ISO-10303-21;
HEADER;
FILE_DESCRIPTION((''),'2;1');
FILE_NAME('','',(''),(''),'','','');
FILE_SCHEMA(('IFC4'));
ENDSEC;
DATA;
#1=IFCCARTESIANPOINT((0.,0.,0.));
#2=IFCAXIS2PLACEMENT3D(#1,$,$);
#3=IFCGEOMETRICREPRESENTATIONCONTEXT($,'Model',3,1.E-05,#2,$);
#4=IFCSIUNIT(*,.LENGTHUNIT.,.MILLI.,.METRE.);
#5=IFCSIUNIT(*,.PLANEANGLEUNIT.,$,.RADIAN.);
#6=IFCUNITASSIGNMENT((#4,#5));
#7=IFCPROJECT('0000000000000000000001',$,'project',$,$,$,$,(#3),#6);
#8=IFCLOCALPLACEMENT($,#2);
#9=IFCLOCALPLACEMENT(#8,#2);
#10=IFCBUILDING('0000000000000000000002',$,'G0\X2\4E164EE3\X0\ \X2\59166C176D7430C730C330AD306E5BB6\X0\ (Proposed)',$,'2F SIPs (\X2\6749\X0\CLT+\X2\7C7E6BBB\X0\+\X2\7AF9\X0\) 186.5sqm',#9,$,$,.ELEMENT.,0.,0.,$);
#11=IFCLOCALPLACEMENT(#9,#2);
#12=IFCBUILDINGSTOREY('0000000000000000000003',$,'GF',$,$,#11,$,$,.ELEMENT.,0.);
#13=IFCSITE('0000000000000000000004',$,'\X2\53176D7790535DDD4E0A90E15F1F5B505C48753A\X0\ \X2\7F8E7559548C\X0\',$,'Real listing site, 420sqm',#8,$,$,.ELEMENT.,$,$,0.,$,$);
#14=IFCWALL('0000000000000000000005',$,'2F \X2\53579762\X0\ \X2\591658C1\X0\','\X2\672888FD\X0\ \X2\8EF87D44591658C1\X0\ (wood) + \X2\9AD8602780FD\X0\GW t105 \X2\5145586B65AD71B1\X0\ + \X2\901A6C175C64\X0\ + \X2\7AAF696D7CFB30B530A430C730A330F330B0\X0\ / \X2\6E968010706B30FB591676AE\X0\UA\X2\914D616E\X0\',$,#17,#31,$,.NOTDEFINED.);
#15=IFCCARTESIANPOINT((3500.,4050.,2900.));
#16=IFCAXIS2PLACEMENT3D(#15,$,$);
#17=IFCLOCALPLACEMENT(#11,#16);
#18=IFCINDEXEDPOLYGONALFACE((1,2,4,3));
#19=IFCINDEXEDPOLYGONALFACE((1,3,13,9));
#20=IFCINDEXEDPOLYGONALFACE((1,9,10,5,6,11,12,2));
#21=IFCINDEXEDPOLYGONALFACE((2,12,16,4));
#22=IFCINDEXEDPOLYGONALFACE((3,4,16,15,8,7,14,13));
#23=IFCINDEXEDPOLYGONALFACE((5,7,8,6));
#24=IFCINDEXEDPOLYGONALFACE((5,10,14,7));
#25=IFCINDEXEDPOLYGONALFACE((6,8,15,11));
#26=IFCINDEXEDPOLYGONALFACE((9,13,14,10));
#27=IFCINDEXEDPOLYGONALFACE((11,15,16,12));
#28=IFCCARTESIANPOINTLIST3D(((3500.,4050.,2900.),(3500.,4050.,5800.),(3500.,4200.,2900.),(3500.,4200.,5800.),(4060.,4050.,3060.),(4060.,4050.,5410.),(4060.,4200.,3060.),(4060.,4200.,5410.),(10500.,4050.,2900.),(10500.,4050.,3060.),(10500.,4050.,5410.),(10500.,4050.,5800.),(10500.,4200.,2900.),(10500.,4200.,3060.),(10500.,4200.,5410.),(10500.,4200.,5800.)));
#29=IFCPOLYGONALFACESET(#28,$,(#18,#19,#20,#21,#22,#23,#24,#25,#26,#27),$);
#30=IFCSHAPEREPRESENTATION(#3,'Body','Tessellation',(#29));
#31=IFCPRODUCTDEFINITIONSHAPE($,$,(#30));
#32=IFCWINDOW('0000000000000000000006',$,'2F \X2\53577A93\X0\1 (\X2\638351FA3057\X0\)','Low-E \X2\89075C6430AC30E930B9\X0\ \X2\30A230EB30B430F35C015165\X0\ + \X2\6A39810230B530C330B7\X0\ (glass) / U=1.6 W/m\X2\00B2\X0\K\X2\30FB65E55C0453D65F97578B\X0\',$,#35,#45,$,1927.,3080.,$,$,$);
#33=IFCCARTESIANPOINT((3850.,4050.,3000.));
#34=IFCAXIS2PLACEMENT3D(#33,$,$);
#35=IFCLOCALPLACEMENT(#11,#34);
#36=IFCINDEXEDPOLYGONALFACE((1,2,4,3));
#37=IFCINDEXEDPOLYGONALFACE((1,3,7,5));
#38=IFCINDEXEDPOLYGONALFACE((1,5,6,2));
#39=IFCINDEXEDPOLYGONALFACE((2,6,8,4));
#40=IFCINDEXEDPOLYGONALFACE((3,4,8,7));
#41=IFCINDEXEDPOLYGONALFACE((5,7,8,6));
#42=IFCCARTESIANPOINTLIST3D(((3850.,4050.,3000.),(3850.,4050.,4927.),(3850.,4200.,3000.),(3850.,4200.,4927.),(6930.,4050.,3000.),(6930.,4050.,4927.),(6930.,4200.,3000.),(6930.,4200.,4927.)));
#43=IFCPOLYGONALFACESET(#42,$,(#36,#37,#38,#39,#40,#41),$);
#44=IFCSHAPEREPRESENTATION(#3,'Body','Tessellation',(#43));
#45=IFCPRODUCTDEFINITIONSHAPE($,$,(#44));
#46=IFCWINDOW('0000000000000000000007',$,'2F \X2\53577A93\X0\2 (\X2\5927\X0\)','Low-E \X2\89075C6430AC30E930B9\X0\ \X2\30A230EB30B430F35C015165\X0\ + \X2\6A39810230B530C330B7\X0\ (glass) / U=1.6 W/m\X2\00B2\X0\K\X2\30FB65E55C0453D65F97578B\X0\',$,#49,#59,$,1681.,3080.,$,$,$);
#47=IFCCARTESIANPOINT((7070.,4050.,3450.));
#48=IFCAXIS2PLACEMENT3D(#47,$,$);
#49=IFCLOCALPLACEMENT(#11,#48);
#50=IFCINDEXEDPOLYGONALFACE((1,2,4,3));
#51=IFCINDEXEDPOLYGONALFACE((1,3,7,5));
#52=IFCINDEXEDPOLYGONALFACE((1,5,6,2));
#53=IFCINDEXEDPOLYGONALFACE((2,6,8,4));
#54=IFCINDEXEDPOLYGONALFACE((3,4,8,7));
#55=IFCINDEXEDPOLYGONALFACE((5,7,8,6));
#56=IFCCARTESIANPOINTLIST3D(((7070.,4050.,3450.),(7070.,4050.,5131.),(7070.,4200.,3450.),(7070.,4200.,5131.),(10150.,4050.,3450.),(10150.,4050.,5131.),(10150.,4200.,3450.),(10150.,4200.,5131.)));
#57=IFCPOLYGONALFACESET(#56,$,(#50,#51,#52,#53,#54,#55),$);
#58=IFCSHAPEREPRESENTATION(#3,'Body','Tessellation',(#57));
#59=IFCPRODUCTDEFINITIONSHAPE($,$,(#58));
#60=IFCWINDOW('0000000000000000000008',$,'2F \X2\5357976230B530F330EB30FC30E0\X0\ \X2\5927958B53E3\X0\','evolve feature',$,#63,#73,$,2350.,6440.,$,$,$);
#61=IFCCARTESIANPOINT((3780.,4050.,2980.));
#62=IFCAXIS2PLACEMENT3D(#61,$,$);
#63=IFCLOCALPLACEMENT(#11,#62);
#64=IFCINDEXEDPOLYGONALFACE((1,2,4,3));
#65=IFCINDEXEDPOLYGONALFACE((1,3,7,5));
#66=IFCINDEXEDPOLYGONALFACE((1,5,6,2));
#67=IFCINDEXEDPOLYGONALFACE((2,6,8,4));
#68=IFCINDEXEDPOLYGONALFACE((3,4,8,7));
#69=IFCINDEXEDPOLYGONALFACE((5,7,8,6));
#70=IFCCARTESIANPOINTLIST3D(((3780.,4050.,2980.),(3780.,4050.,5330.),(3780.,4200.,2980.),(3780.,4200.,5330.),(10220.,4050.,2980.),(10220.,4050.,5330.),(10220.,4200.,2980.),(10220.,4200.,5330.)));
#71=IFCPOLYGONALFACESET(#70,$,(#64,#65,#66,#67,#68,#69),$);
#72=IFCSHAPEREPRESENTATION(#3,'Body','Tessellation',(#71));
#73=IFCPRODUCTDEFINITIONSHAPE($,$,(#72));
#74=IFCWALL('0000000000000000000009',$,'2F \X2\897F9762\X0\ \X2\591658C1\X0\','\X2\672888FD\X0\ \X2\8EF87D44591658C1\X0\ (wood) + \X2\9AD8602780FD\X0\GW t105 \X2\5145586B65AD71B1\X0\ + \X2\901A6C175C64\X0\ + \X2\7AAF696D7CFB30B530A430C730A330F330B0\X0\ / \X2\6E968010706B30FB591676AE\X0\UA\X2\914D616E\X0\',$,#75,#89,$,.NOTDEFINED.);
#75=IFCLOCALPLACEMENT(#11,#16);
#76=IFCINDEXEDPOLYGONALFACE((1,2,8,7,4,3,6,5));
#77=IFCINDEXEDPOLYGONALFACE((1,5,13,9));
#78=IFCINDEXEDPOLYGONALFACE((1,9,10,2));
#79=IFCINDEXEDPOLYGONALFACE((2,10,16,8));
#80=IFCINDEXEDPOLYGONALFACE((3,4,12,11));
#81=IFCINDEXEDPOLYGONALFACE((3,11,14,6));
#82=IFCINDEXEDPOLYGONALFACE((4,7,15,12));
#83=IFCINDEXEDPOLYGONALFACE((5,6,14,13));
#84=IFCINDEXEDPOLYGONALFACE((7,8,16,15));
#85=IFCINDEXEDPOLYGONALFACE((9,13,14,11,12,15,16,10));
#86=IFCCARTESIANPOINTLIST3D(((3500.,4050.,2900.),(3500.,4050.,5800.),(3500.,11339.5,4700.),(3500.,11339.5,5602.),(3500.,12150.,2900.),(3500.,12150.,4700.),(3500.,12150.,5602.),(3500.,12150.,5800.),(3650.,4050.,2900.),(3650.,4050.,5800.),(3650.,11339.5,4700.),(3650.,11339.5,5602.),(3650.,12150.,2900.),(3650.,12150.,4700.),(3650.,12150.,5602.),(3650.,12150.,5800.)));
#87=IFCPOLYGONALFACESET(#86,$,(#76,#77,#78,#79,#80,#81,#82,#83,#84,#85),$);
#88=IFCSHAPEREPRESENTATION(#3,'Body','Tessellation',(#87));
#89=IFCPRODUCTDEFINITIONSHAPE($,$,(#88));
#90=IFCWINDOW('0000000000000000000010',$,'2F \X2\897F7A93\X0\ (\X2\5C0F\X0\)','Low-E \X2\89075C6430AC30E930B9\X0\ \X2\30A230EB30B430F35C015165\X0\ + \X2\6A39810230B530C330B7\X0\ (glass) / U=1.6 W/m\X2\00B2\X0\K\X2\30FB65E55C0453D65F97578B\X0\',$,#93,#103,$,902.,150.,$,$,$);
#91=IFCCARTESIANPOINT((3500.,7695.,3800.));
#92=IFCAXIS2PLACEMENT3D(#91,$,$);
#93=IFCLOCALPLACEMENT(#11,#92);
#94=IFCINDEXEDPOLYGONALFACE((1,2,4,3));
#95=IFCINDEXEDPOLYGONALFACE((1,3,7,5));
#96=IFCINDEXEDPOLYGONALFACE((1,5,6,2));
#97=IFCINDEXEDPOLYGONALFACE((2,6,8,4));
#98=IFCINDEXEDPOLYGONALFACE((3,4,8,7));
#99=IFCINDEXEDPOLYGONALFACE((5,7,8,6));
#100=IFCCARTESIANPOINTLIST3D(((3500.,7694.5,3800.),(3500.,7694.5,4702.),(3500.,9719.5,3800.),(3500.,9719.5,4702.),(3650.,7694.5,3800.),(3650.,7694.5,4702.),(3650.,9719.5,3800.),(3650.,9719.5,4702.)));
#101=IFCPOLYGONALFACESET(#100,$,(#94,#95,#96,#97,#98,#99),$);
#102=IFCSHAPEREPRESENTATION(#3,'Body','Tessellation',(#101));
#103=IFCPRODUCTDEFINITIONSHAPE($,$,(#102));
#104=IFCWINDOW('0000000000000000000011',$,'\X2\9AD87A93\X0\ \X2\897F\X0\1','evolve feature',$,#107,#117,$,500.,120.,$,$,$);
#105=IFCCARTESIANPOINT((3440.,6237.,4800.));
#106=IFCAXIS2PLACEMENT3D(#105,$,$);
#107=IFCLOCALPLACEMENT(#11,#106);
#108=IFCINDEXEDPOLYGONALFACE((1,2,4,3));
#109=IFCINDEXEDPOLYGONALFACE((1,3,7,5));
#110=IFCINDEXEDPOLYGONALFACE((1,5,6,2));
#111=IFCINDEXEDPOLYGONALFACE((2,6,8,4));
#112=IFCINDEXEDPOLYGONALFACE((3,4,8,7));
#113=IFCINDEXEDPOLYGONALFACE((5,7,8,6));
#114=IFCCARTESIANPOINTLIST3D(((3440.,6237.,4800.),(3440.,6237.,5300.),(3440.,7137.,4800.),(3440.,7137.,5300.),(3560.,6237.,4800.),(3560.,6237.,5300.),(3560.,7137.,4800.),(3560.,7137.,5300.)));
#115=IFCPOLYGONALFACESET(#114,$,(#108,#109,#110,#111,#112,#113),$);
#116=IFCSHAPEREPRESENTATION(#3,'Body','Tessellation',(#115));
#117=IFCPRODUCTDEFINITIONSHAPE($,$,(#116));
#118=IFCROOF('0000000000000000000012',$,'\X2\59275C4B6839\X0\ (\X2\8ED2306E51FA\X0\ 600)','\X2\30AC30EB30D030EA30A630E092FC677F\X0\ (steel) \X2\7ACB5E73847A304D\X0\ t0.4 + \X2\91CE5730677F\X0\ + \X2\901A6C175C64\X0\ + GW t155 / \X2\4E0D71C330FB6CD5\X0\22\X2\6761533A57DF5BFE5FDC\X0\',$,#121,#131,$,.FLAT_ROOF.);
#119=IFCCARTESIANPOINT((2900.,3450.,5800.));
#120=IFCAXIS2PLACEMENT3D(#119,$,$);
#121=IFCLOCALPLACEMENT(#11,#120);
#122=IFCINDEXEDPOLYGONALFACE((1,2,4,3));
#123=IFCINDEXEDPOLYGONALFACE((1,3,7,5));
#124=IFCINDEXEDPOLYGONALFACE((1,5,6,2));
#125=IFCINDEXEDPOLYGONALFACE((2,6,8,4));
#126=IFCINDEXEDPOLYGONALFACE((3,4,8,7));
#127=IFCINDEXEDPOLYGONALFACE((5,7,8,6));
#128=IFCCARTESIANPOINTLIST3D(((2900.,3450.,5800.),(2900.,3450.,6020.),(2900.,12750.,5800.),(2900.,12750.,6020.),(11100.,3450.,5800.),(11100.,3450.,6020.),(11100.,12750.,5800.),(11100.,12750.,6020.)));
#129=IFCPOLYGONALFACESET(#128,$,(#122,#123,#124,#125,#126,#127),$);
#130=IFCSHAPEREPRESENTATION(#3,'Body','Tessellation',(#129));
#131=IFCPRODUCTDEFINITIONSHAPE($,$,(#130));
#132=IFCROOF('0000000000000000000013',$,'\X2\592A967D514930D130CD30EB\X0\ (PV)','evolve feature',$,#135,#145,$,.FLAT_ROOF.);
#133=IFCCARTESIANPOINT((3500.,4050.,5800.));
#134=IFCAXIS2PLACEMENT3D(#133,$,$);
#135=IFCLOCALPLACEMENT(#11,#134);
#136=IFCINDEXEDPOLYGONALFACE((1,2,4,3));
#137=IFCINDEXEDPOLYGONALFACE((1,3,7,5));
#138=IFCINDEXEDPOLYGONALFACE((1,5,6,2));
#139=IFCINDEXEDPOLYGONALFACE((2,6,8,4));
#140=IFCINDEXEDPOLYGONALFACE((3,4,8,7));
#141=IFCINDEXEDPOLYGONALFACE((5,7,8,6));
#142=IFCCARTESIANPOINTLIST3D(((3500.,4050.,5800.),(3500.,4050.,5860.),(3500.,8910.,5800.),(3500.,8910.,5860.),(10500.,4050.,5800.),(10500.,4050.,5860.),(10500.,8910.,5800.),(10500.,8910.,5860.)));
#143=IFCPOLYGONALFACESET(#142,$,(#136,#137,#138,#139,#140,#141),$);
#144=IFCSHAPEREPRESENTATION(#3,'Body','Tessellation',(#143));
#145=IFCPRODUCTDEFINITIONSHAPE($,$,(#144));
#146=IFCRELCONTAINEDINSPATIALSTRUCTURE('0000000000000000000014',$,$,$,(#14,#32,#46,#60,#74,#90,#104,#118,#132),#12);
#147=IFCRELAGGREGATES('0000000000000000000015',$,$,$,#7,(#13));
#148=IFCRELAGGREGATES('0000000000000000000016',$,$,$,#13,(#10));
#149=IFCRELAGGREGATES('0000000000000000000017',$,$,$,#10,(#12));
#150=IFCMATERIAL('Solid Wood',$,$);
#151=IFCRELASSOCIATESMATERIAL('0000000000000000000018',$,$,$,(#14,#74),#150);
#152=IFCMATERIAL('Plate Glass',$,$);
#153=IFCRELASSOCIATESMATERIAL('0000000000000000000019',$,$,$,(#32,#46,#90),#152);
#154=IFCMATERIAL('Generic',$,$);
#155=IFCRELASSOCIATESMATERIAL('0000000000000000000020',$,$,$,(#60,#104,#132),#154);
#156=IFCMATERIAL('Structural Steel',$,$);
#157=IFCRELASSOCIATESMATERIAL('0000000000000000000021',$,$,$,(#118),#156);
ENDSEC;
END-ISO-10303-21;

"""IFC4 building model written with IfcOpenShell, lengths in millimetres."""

from ifc_helpers import new_model, si_unit, frame, frame_2d, origin, place, context, project, spatial, rectangle, extrude, material, element, fill, save


model = new_model("IFC4")

# Units and contexts
model_context = context("Model", 3, precision=1e-05, world=origin())
ifc_project = project(units=[si_unit("LENGTHUNIT", "METRE", prefix="MILLI"), si_unit("PLANEANGLEUNIT", "RADIAN")], contexts=[model_context])

# Site, building, storey
site_placement = place(None, origin())
site = spatial("IfcSite", under=ifc_project, at=site_placement, Name="北海道川上郡弟子屈町 美留和", ObjectType="Real listing site, 420sqm", CompositionType="ELEMENT", RefElevation=0.0)
building_placement = place(site_placement, origin())
building = spatial("IfcBuilding", under=site, at=building_placement, Name="G0世代 外気浴デッキの家 (Proposed)", ObjectType="2F SIPs (杉CLT+籾殻+竹) 186.5sqm", CompositionType="ELEMENT", ElevationOfRefHeight=0.0, ElevationOfTerrain=0.0)
storey_placement = place(building_placement, origin())
storey = spatial("IfcBuildingStorey", under=building, at=storey_placement, Name="GF", CompositionType="ELEMENT", Elevation=0.0)

# Shared definitions
ifc_material_1 = material(Name="Solid Wood")
ifc_material_2 = material(Name="Generic")

# Shared definitions
ifc_material_3 = material(Name="Plate Glass")

# Walls, openings, windows
wall_1_placement = place(storey_placement, frame((3500.0, 4050.0, 2900.0)))
wall_1 = element("IfcWall", 1, at=wall_1_placement, inside=storey, material=ifc_material_1, Name="2F 南面 外壁", Description="木製 軸組外壁 (wood) + 高性能GW t105 充填断熱 + 通気層 + 窯業系サイディング / 準耐火・外皮UA配慮", PredefinedType="NOTDEFINED", context=model_context, shape_type="SweptSolid", body=[
    extrude(rectangle(XDim=7000.0, YDim=150.0, at=frame_2d((3500.0, 75.0))), frame((3500.0, 4050.0, 2900.0)), (0.0, 0.0, 1.0), 2900.0),
])
opening_1_placement = place(storey_placement, frame((3850.0, 4050.0, 3000.0)))
opening_1 = element("IfcOpeningElement", 2, at=opening_1_placement, cuts=wall_1, PredefinedType="NOTDEFINED", context=model_context, shape_type="SweptSolid", body=[
    extrude(rectangle(XDim=3080.0, YDim=150.0, at=frame_2d((1540.0, 75.0))), frame((3850.0, 4050.0, 3000.0)), (0.0, 0.0, 1.0), 1927.0),
])
opening_2_placement = place(storey_placement, frame((7070.0, 4050.0, 3450.0)))
opening_2 = element("IfcOpeningElement", 3, at=opening_2_placement, cuts=wall_1, PredefinedType="NOTDEFINED", context=model_context, shape_type="SweptSolid", body=[
    extrude(rectangle(XDim=3080.0, YDim=150.0, at=frame_2d((1540.0, 75.0))), frame((7070.0, 4050.0, 3450.0)), (0.0, 0.0, 1.0), 1681.0),
])
opening_3_placement = place(storey_placement, frame((3780.0, 4050.0, 2980.0)))
opening_3 = element("IfcOpeningElement", 4, at=opening_3_placement, cuts=wall_1, PredefinedType="NOTDEFINED", context=model_context, shape_type="SweptSolid", body=[
    extrude(rectangle(XDim=6440.0, YDim=150.0, at=frame_2d((3220.0, 75.0))), frame((3780.0, 4050.0, 2980.0)), (0.0, 0.0, 1.0), 2350.0),
])
window_1_placement = place(storey_placement, frame((3850.0, 4050.0, 3000.0)))
window_1 = element("IfcWindow", 5, at=window_1_placement, inside=storey, material=ifc_material_3, Name="2F 南窓1 (掃出し)", Description="Low-E 複層ガラス アルゴン封入 + 樹脂サッシ (glass) / U=1.6 W/m²K・日射取得型", OverallHeight=1927.0, OverallWidth=3080.0, context=model_context, shape_type="SweptSolid", body=[
    extrude(rectangle(XDim=3080.0, YDim=150.0, at=frame_2d((1540.0, 75.0))), frame((3850.0, 4050.0, 3000.0)), (0.0, 0.0, 1.0), 1927.0),
])
fill(opening_1, window_1)
window_2_placement = place(storey_placement, frame((7070.0, 4050.0, 3450.0)))
window_2 = element("IfcWindow", 6, at=window_2_placement, inside=storey, material=ifc_material_3, Name="2F 南窓2 (大)", Description="Low-E 複層ガラス アルゴン封入 + 樹脂サッシ (glass) / U=1.6 W/m²K・日射取得型", OverallHeight=1681.0, OverallWidth=3080.0, context=model_context, shape_type="SweptSolid", body=[
    extrude(rectangle(XDim=3080.0, YDim=150.0, at=frame_2d((1540.0, 75.0))), frame((7070.0, 4050.0, 3450.0)), (0.0, 0.0, 1.0), 1681.0),
])
fill(opening_2, window_2)
window_3_placement = place(storey_placement, frame((3780.0, 4050.0, 2980.0)))
window_3 = element("IfcWindow", 7, at=window_3_placement, inside=storey, material=ifc_material_2, Name="2F 南面サンルーム 大開口", Description="evolve feature", OverallHeight=2350.0, OverallWidth=6440.0, context=model_context, shape_type="SweptSolid", body=[
    extrude(rectangle(XDim=6440.0, YDim=150.0, at=frame_2d((3220.0, 75.0))), frame((3780.0, 4050.0, 2980.0)), (0.0, 0.0, 1.0), 2350.0),
])
fill(opening_3, window_3)
wall_2_placement = place(storey_placement, frame((3500.0, 4050.0, 2900.0)))
wall_2 = element("IfcWall", 8, at=wall_2_placement, inside=storey, material=ifc_material_1, Name="2F 西面 外壁", Description="木製 軸組外壁 (wood) + 高性能GW t105 充填断熱 + 通気層 + 窯業系サイディング / 準耐火・外皮UA配慮", PredefinedType="NOTDEFINED", context=model_context, shape_type="SweptSolid", body=[
    extrude(rectangle(XDim=150.0, YDim=8100.0, at=frame_2d((75.0, 4050.0))), frame((3500.0, 4050.0, 2900.0)), (0.0, 0.0, 1.0), 2900.0),
])
opening_4_placement = place(storey_placement, frame((3500.0, 7695.0, 3800.0)))
opening_4 = element("IfcOpeningElement", 9, at=opening_4_placement, cuts=wall_2, PredefinedType="NOTDEFINED", context=model_context, shape_type="SweptSolid", body=[
    extrude(rectangle(XDim=150.0, YDim=2025.0, at=frame_2d((75.0, 1012.0))), frame((3500.0, 7695.0, 3800.0)), (0.0, 0.0, 1.0), 902.0),
])
opening_5_placement = place(storey_placement, frame((3440.0, 6237.0, 4800.0)))
opening_5 = element("IfcOpeningElement", 10, at=opening_5_placement, cuts=wall_2, PredefinedType="NOTDEFINED", context=model_context, shape_type="SweptSolid", body=[
    extrude(rectangle(XDim=120.0, YDim=900.0, at=frame_2d((60.0, 450.0))), frame((3440.0, 6237.0, 4800.0)), (0.0, 0.0, 1.0), 500.0),
])
window_4_placement = place(storey_placement, frame((3500.0, 7695.0, 3800.0)))
window_4 = element("IfcWindow", 11, at=window_4_placement, inside=storey, material=ifc_material_3, Name="2F 西窓 (小)", Description="Low-E 複層ガラス アルゴン封入 + 樹脂サッシ (glass) / U=1.6 W/m²K・日射取得型", OverallHeight=902.0, OverallWidth=150.0, context=model_context, shape_type="SweptSolid", body=[
    extrude(rectangle(XDim=150.0, YDim=2025.0, at=frame_2d((75.0, 1012.0))), frame((3500.0, 7695.0, 3800.0)), (0.0, 0.0, 1.0), 902.0),
])
fill(opening_4, window_4)
window_5_placement = place(storey_placement, frame((3440.0, 6237.0, 4800.0)))
window_5 = element("IfcWindow", 12, at=window_5_placement, inside=storey, material=ifc_material_2, Name="高窓 西1", Description="evolve feature", OverallHeight=500.0, OverallWidth=120.0, context=model_context, shape_type="SweptSolid", body=[
    extrude(rectangle(XDim=120.0, YDim=900.0, at=frame_2d((60.0, 450.0))), frame((3440.0, 6237.0, 4800.0)), (0.0, 0.0, 1.0), 500.0),
])
fill(opening_5, window_5)

# Roofs
ifc_material_4 = material(Name="Structural Steel")
roof_1_placement = place(storey_placement, frame((2900.0, 3450.0, 5800.0)))
element("IfcRoof", 13, at=roof_1_placement, inside=storey, material=ifc_material_4, Name="大屋根 (軒の出 600)", Description="ガルバリウム鋼板 (steel) 立平葺き t0.4 + 野地板 + 通気層 + GW t155 / 不燃・法22条区域対応", PredefinedType="FLAT_ROOF", context=model_context, shape_type="SweptSolid", body=[
    extrude(rectangle(XDim=8200.0, YDim=9300.0, at=frame_2d((4100.0, 4650.0))), frame((2900.0, 3450.0, 5800.0)), (0.0, 0.0, 1.0), 220.0),
])
roof_2_placement = place(storey_placement, frame((3500.0, 4050.0, 5800.0)))
element("IfcRoof", 14, at=roof_2_placement, inside=storey, material=ifc_material_2, Name="太陽光パネル (PV)", Description="evolve feature", PredefinedType="FLAT_ROOF", context=model_context, shape_type="SweptSolid", body=[
    extrude(rectangle(XDim=7000.0, YDim=4860.0, at=frame_2d((3500.0, 2430.0))), frame((3500.0, 4050.0, 5800.0)), (0.0, 0.0, 1.0), 60.0),
])

save(model, "model.ifc")
